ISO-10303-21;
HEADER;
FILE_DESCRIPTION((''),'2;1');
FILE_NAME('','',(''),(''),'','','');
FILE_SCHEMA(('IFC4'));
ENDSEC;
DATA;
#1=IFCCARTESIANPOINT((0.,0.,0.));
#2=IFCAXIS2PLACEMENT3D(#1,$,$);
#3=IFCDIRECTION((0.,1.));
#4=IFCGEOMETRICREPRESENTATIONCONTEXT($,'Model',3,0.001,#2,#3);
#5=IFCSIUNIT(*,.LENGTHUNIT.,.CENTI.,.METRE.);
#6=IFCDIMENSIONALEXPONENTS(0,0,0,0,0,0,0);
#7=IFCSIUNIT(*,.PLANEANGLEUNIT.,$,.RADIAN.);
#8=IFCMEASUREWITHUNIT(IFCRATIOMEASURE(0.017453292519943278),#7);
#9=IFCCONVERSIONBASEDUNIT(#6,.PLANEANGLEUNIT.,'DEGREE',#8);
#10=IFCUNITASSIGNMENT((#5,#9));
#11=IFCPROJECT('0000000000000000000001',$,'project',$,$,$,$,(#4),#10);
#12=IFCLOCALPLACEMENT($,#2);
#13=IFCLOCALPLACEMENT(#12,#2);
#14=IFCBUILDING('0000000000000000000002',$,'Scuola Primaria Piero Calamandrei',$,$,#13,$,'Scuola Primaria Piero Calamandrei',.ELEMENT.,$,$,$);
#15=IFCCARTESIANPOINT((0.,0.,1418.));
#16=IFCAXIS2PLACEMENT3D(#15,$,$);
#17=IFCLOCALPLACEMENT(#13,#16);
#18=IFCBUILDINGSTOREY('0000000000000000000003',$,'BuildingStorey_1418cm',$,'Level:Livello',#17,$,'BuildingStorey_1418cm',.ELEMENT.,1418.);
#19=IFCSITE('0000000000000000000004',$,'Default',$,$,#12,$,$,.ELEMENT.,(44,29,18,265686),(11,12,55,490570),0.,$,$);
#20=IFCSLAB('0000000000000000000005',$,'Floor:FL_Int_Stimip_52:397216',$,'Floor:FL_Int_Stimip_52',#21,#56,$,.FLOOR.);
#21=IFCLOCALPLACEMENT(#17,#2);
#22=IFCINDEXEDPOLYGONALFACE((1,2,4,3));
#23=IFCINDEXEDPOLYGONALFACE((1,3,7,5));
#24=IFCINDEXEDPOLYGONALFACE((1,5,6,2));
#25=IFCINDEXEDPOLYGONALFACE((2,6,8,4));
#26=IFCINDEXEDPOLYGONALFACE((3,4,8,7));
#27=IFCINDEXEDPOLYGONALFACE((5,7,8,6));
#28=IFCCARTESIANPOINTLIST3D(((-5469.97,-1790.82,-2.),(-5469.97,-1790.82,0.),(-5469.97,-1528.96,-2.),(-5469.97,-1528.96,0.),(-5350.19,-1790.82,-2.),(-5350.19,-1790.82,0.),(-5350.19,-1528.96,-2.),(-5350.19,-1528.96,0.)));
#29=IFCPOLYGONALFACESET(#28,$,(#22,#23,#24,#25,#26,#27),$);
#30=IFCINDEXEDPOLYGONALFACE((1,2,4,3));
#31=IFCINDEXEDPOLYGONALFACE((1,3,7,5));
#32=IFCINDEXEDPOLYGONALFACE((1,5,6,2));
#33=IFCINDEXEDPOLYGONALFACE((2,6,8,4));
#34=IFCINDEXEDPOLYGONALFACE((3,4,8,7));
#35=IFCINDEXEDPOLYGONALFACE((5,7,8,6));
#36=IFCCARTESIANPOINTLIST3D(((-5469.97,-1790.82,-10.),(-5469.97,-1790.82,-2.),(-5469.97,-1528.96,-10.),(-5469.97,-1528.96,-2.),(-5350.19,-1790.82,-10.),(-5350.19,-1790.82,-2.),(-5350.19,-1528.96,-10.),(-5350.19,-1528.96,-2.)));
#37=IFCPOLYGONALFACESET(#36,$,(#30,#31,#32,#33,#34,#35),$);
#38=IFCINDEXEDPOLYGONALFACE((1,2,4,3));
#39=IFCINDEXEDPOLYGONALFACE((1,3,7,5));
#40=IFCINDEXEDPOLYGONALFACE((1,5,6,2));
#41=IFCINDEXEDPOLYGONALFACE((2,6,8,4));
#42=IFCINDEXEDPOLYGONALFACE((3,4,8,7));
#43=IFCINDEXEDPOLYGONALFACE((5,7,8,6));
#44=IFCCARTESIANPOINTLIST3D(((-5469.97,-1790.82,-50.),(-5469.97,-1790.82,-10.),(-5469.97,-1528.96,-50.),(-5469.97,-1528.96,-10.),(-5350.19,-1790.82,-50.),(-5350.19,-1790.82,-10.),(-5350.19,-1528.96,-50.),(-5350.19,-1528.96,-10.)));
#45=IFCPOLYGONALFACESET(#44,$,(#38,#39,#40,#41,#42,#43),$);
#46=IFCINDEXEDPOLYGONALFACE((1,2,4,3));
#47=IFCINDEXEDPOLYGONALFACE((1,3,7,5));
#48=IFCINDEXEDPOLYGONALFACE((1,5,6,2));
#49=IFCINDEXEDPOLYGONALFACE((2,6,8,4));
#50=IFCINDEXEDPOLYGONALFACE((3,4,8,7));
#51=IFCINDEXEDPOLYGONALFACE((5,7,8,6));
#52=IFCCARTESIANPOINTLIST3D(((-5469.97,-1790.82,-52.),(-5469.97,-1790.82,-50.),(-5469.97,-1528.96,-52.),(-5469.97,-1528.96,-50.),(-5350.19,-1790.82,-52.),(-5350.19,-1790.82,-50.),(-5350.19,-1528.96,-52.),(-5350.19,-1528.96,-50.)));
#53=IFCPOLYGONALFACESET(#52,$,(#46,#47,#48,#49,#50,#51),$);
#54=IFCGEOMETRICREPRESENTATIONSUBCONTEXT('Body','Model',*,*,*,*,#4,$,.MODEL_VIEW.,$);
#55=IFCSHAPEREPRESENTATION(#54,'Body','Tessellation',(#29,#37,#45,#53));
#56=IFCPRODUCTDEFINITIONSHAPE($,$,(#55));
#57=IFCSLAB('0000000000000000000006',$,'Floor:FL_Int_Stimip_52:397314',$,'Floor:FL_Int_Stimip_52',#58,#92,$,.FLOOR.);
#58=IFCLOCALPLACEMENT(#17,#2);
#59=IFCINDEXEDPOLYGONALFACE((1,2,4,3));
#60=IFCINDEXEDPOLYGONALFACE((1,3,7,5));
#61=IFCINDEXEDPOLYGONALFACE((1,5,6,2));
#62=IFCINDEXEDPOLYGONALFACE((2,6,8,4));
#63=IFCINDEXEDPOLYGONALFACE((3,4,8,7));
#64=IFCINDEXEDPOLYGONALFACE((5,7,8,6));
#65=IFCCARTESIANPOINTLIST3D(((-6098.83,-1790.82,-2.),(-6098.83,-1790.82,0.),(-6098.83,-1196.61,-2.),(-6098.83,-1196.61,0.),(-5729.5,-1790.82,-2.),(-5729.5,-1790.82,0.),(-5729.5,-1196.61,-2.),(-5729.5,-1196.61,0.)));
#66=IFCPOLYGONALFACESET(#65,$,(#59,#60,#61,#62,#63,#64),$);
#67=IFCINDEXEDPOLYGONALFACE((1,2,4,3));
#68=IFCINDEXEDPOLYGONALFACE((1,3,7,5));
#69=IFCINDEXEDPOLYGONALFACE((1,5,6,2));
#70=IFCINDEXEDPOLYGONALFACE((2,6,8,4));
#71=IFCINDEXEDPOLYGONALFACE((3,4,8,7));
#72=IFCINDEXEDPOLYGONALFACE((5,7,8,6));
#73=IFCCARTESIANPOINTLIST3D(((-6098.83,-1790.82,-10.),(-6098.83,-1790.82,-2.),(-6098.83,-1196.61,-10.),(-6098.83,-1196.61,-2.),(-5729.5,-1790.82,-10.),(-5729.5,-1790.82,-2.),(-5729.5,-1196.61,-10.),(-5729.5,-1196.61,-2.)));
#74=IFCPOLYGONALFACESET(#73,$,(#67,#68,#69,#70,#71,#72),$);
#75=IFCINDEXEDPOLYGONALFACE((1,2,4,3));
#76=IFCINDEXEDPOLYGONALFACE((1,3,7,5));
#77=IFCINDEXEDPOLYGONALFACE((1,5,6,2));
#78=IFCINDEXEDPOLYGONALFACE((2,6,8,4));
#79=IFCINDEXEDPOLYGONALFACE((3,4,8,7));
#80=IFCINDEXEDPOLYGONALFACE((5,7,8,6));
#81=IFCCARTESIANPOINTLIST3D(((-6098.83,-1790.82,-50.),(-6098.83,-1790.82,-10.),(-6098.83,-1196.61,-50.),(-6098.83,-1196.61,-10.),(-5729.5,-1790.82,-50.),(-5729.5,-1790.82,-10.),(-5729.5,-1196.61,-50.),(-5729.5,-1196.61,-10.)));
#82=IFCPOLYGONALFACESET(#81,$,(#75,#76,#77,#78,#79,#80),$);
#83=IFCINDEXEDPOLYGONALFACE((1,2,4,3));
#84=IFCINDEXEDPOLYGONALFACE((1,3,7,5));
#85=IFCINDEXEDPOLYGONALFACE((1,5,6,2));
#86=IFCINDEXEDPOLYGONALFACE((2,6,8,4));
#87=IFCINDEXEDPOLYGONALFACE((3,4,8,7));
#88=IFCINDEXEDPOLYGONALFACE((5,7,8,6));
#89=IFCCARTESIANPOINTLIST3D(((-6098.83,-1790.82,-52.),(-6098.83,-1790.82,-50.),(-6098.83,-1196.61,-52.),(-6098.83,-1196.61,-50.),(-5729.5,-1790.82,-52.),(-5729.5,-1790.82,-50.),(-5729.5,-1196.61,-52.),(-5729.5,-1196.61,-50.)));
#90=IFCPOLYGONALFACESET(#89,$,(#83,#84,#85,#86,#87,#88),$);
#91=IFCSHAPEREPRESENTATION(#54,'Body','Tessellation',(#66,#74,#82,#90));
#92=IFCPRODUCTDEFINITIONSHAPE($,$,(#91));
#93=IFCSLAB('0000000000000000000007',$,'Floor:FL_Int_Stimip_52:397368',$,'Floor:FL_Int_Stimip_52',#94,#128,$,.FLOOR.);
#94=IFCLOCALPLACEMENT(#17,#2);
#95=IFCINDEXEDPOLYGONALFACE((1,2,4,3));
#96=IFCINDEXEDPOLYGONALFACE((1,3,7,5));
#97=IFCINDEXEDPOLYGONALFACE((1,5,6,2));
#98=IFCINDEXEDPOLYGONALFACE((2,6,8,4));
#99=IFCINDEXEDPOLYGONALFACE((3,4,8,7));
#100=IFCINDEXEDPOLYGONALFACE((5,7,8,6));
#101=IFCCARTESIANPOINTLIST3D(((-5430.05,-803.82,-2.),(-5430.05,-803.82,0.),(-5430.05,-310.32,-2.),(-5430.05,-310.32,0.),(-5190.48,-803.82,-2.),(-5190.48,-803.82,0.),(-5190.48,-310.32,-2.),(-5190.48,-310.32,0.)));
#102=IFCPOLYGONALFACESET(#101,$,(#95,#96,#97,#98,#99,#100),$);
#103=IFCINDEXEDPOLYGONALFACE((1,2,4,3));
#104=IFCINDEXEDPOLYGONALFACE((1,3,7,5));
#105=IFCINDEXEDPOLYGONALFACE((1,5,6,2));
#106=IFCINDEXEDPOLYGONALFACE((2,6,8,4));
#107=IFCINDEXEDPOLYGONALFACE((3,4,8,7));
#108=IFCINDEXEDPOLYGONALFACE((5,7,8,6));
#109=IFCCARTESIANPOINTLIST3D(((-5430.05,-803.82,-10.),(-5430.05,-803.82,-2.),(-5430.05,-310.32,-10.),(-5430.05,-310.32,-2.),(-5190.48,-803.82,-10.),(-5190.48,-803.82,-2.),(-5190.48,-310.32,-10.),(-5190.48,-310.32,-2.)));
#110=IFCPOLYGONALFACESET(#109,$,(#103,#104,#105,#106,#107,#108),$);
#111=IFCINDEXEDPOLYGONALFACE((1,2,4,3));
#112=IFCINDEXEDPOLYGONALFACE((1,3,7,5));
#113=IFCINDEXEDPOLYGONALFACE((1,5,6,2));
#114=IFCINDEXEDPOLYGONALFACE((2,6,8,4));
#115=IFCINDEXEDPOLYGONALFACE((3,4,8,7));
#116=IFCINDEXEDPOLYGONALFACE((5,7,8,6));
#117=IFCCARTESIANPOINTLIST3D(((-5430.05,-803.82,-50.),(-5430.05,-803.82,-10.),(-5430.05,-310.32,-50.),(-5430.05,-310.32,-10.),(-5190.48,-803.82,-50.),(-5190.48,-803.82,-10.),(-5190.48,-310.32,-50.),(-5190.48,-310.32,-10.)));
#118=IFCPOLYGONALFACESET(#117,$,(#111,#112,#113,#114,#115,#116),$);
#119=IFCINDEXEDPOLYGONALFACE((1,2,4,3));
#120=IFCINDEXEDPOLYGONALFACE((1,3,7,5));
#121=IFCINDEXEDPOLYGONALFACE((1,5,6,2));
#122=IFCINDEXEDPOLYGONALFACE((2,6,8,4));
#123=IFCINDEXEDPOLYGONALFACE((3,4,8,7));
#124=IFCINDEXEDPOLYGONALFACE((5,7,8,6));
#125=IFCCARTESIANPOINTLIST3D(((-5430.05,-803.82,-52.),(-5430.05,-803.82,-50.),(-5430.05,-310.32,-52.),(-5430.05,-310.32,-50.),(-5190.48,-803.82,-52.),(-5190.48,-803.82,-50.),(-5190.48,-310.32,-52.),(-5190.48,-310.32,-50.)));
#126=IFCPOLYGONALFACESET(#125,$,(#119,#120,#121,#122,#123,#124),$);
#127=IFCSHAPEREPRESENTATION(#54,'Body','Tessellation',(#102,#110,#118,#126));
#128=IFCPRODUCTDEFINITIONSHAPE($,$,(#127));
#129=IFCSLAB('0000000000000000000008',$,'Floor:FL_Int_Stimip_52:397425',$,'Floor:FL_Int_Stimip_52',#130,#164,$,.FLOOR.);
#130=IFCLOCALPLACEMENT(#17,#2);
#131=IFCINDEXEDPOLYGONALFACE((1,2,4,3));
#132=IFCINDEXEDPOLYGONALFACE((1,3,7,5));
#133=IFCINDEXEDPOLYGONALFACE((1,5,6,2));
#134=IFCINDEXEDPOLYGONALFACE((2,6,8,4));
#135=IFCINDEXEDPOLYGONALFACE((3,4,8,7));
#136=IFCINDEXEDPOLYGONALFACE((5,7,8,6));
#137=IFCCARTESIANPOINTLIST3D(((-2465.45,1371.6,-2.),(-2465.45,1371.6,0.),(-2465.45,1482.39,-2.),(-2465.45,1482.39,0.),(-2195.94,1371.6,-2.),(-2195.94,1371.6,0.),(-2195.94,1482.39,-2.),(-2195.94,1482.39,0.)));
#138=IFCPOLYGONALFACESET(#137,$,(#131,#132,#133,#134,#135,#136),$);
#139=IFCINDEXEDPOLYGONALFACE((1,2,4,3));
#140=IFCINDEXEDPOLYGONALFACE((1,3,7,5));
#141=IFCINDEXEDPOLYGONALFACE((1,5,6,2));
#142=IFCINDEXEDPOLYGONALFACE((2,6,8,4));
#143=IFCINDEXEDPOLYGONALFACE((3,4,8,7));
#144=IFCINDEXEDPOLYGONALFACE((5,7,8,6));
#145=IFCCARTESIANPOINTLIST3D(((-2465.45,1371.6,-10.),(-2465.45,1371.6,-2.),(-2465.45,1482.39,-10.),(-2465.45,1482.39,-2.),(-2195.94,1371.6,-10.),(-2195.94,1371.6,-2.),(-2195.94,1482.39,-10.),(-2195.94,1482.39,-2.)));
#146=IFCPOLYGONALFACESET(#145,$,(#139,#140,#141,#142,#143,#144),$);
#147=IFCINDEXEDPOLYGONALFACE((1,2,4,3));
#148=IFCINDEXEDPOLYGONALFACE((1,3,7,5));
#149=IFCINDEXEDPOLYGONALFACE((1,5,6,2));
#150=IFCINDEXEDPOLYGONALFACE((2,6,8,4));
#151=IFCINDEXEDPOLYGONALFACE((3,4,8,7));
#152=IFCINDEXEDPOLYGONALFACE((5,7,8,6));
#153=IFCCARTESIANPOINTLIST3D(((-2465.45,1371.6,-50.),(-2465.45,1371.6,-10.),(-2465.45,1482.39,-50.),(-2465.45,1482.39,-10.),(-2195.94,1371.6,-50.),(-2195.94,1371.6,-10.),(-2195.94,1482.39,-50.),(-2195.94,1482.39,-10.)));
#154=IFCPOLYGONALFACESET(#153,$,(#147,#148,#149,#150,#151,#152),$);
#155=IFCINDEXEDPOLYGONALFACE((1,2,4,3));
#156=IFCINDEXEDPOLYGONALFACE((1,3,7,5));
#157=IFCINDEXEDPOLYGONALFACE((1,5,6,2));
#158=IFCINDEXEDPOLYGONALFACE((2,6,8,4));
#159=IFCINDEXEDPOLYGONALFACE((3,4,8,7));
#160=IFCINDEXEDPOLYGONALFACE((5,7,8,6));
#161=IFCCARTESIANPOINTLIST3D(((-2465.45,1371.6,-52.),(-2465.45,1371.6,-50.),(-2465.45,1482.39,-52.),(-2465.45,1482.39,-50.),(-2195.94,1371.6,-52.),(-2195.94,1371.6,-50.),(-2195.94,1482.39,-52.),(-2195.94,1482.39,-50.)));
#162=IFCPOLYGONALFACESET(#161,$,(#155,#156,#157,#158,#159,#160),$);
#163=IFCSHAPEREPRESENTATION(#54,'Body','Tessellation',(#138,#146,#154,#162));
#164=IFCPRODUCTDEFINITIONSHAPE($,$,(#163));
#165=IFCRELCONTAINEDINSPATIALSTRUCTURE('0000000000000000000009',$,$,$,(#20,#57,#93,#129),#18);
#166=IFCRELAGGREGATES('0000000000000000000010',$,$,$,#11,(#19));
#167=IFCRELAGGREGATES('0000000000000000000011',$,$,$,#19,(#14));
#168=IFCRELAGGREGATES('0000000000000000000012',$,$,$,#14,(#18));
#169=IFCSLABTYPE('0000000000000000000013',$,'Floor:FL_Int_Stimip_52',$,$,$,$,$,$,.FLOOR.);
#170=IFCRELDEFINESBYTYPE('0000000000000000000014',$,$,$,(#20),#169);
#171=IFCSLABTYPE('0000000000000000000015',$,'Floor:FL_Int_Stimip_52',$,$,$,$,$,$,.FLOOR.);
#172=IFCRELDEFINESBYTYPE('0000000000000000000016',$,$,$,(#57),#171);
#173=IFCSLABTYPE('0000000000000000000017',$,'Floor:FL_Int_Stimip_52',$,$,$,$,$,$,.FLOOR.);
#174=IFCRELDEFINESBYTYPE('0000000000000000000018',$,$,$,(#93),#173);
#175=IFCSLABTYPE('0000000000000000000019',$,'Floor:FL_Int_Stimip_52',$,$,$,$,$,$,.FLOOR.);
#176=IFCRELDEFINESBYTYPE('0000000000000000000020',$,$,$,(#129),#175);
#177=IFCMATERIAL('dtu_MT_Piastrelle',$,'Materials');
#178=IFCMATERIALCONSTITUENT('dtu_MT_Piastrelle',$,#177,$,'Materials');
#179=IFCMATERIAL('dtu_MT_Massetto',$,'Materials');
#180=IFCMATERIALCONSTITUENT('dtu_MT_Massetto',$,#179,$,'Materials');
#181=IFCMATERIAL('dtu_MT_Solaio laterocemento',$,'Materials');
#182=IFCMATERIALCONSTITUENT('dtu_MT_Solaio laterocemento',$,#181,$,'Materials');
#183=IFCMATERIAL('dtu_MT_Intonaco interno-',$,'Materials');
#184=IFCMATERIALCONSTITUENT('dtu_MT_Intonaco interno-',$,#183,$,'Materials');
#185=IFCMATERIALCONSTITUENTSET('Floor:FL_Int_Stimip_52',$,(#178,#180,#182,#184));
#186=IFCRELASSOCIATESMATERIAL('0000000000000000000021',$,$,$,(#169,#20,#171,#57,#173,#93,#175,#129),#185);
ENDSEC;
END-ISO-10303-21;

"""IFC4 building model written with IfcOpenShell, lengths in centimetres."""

from ifc_helpers import new_model, entity, si_unit, converted_unit, direction, frame, origin, place, context, subcontext, project, spatial, indexed_curve, outline, extrude, material, constituent, constituent_set, type_object, element, save


model = new_model("IFC4")

# Units and contexts
model_context = context("Model", 3, precision=0.001, world=origin(), true_north=direction((0.0, 1.0)))
body_context = subcontext(model_context, "Body", "Model", "MODEL_VIEW")
ifc_project = project(units=[si_unit("LENGTHUNIT", "METRE", prefix="CENTI"), converted_unit("PLANEANGLEUNIT", "DEGREE", entity("IfcRatioMeasure", 0.017453292519943278), si_unit("PLANEANGLEUNIT", "RADIAN"), dimensions=[0, 0, 0, 0, 0, 0, 0])], contexts=[model_context])

# Site, building, storey
site_placement = place(None, origin())
site = spatial("IfcSite", under=ifc_project, at=site_placement, Name="Default", CompositionType="ELEMENT", RefLatitude=(44, 29, 18, 265686), RefLongitude=(11, 12, 55, 490570), RefElevation=0.0)
building_placement = place(site_placement, origin())
building = spatial("IfcBuilding", under=site, at=building_placement, Name="Scuola Primaria Piero Calamandrei", LongName="Scuola Primaria Piero Calamandrei", CompositionType="ELEMENT")
storey_placement = place(building_placement, frame((0.0, 0.0, 1418.0)))
storey = spatial("IfcBuildingStorey", under=building, at=storey_placement, Name="BuildingStorey_1418cm", ObjectType="Level:Livello", LongName="BuildingStorey_1418cm", CompositionType="ELEMENT", Elevation=1418.0)

# Slabs
ifc_material_1 = material(Name="dtu_MT_Piastrelle", Category="Materials")
ifc_constituent_1 = constituent(ifc_material_1, Name="dtu_MT_Piastrelle", Category="Materials")
ifc_material_2 = material(Name="dtu_MT_Massetto", Category="Materials")
ifc_constituent_2 = constituent(ifc_material_2, Name="dtu_MT_Massetto", Category="Materials")
ifc_material_3 = material(Name="dtu_MT_Solaio laterocemento", Category="Materials")
ifc_constituent_3 = constituent(ifc_material_3, Name="dtu_MT_Solaio laterocemento", Category="Materials")
ifc_material_4 = material(Name="dtu_MT_Intonaco interno-", Category="Materials")
ifc_constituent_4 = constituent(ifc_material_4, Name="dtu_MT_Intonaco interno-", Category="Materials")
ifc_constituent_set = constituent_set(constituents=[ifc_constituent_1, ifc_constituent_2, ifc_constituent_3, ifc_constituent_4], Name="Floor:FL_Int_Stimip_52")
slab_type_1 = type_object("IfcSlabType", Name="Floor:FL_Int_Stimip_52", PredefinedType="FLOOR", material=ifc_constituent_set)
slab_1_placement = place(storey_placement, origin())
element("IfcSlab", 1, at=slab_1_placement, inside=storey, type_object=slab_type_1, material=ifc_constituent_set, Name="Floor:FL_Int_Stimip_52:397216", ObjectType="Floor:FL_Int_Stimip_52", PredefinedType="FLOOR", context=body_context, shape_type="SweptSolid", body=[
    extrude(outline(indexed_curve([(-59.89, -130.93), (59.89, -130.93), (59.89, 130.93), (-59.89, 130.93), (-59.89, -130.93)], self_intersect=False)), frame((-5410.08, -1659.89, -2.0), z_axis=(0.0, 0.0, 1.0), x_axis=(-1.0, 0.0, 0.0)), (0.0, 0.0, 1.0), 2.0),
    extrude(outline(indexed_curve([(-59.89, -130.93), (59.89, -130.93), (59.89, 130.93), (-59.89, 130.93), (-59.89, -130.93)], self_intersect=False)), frame((-5410.08, -1659.89, -10.0), z_axis=(0.0, 0.0, 1.0), x_axis=(-1.0, 0.0, 0.0)), (0.0, 0.0, 1.0), 8.0),
    extrude(outline(indexed_curve([(-59.89, -130.93), (59.89, -130.93), (59.89, 130.93), (-59.89, 130.93), (-59.89, -130.93)], self_intersect=False)), frame((-5410.08, -1659.89, -50.0), z_axis=(0.0, 0.0, 1.0), x_axis=(-1.0, 0.0, 0.0)), (0.0, 0.0, 1.0), 40.0),
    extrude(outline(indexed_curve([(-59.89, -130.93), (59.89, -130.93), (59.89, 130.93), (-59.89, 130.93), (-59.89, -130.93)], self_intersect=False)), frame((-5410.08, -1659.89, -52.0), z_axis=(0.0, 0.0, 1.0), x_axis=(-1.0, 0.0, 0.0)), (0.0, 0.0, 1.0), 2.0),
])
slab_type_2 = type_object("IfcSlabType", Name="Floor:FL_Int_Stimip_52", PredefinedType="FLOOR", material=ifc_constituent_set)
slab_2_placement = place(storey_placement, origin())
element("IfcSlab", 2, at=slab_2_placement, inside=storey, type_object=slab_type_2, material=ifc_constituent_set, Name="Floor:FL_Int_Stimip_52:397314", ObjectType="Floor:FL_Int_Stimip_52", PredefinedType="FLOOR", context=body_context, shape_type="SweptSolid", body=[
    extrude(outline(indexed_curve([(-184.66, -297.11), (184.66, -297.11), (184.66, 297.11), (-184.66, 297.11), (-184.66, -297.11)], self_intersect=False)), frame((-5914.16, -1493.71, -2.0), z_axis=(0.0, 0.0, 1.0), x_axis=(-1.0, 0.0, 0.0)), (0.0, 0.0, 1.0), 2.0),
    extrude(outline(indexed_curve([(-184.66, -297.11), (184.66, -297.11), (184.66, 297.11), (-184.66, 297.11), (-184.66, -297.11)], self_intersect=False)), frame((-5914.16, -1493.71, -10.0), z_axis=(0.0, 0.0, 1.0), x_axis=(-1.0, 0.0, 0.0)), (0.0, 0.0, 1.0), 8.0),
    extrude(outline(indexed_curve([(-184.66, -297.11), (184.66, -297.11), (184.66, 297.11), (-184.66, 297.11), (-184.66, -297.11)], self_intersect=False)), frame((-5914.16, -1493.71, -50.0), z_axis=(0.0, 0.0, 1.0), x_axis=(-1.0, 0.0, 0.0)), (0.0, 0.0, 1.0), 40.0),
    extrude(outline(indexed_curve([(-184.66, -297.11), (184.66, -297.11), (184.66, 297.11), (-184.66, 297.11), (-184.66, -297.11)], self_intersect=False)), frame((-5914.16, -1493.71, -52.0), z_axis=(0.0, 0.0, 1.0), x_axis=(-1.0, 0.0, 0.0)), (0.0, 0.0, 1.0), 2.0),
])
slab_type_3 = type_object("IfcSlabType", Name="Floor:FL_Int_Stimip_52", PredefinedType="FLOOR", material=ifc_constituent_set)
slab_3_placement = place(storey_placement, origin())
element("IfcSlab", 3, at=slab_3_placement, inside=storey, type_object=slab_type_3, material=ifc_constituent_set, Name="Floor:FL_Int_Stimip_52:397368", ObjectType="Floor:FL_Int_Stimip_52", PredefinedType="FLOOR", context=body_context, shape_type="SweptSolid", body=[
    extrude(outline(indexed_curve([(-119.78, -246.75), (119.78, -246.75), (119.78, 246.75), (-119.78, 246.75), (-119.78, -246.75)], self_intersect=False)), frame((-5310.26, -557.07, -2.0)), (0.0, 0.0, 1.0), 2.0),
    extrude(outline(indexed_curve([(-119.78, -246.75), (119.78, -246.75), (119.78, 246.75), (-119.78, 246.75), (-119.78, -246.75)], self_intersect=False)), frame((-5310.26, -557.07, -10.0)), (0.0, 0.0, 1.0), 8.0),
    extrude(outline(indexed_curve([(-119.78, -246.75), (119.78, -246.75), (119.78, 246.75), (-119.78, 246.75), (-119.78, -246.75)], self_intersect=False)), frame((-5310.26, -557.07, -50.0)), (0.0, 0.0, 1.0), 40.0),
    extrude(outline(indexed_curve([(-119.78, -246.75), (119.78, -246.75), (119.78, 246.75), (-119.78, 246.75), (-119.78, -246.75)], self_intersect=False)), frame((-5310.26, -557.07, -52.0)), (0.0, 0.0, 1.0), 2.0),
])
slab_type_4 = type_object("IfcSlabType", Name="Floor:FL_Int_Stimip_52", PredefinedType="FLOOR", material=ifc_constituent_set)
slab_4_placement = place(storey_placement, origin())
element("IfcSlab", 4, at=slab_4_placement, inside=storey, type_object=slab_type_4, material=ifc_constituent_set, Name="Floor:FL_Int_Stimip_52:397425", ObjectType="Floor:FL_Int_Stimip_52", PredefinedType="FLOOR", context=body_context, shape_type="SweptSolid", body=[
    extrude(outline(indexed_curve([(-134.75, -55.39), (134.75, -55.39), (134.75, 55.39), (-134.75, 55.39), (-134.75, -55.39)], self_intersect=False)), frame((-2330.69, 1427.0, -2.0), z_axis=(0.0, 0.0, 1.0), x_axis=(-1.0, 0.0, 0.0)), (0.0, 0.0, 1.0), 2.0),
    extrude(outline(indexed_curve([(-134.75, -55.39), (134.75, -55.39), (134.75, 55.39), (-134.75, 55.39), (-134.75, -55.39)], self_intersect=False)), frame((-2330.69, 1427.0, -10.0), z_axis=(0.0, 0.0, 1.0), x_axis=(-1.0, 0.0, 0.0)), (0.0, 0.0, 1.0), 8.0),
    extrude(outline(indexed_curve([(-134.75, -55.39), (134.75, -55.39), (134.75, 55.39), (-134.75, 55.39), (-134.75, -55.39)], self_intersect=False)), frame((-2330.69, 1427.0, -50.0), z_axis=(0.0, 0.0, 1.0), x_axis=(-1.0, 0.0, 0.0)), (0.0, 0.0, 1.0), 40.0),
    extrude(outline(indexed_curve([(-134.75, -55.39), (134.75, -55.39), (134.75, 55.39), (-134.75, 55.39), (-134.75, -55.39)], self_intersect=False)), frame((-2330.69, 1427.0, -52.0), z_axis=(0.0, 0.0, 1.0), x_axis=(-1.0, 0.0, 0.0)), (0.0, 0.0, 1.0), 2.0),
])

save(model, "model.ifc")
